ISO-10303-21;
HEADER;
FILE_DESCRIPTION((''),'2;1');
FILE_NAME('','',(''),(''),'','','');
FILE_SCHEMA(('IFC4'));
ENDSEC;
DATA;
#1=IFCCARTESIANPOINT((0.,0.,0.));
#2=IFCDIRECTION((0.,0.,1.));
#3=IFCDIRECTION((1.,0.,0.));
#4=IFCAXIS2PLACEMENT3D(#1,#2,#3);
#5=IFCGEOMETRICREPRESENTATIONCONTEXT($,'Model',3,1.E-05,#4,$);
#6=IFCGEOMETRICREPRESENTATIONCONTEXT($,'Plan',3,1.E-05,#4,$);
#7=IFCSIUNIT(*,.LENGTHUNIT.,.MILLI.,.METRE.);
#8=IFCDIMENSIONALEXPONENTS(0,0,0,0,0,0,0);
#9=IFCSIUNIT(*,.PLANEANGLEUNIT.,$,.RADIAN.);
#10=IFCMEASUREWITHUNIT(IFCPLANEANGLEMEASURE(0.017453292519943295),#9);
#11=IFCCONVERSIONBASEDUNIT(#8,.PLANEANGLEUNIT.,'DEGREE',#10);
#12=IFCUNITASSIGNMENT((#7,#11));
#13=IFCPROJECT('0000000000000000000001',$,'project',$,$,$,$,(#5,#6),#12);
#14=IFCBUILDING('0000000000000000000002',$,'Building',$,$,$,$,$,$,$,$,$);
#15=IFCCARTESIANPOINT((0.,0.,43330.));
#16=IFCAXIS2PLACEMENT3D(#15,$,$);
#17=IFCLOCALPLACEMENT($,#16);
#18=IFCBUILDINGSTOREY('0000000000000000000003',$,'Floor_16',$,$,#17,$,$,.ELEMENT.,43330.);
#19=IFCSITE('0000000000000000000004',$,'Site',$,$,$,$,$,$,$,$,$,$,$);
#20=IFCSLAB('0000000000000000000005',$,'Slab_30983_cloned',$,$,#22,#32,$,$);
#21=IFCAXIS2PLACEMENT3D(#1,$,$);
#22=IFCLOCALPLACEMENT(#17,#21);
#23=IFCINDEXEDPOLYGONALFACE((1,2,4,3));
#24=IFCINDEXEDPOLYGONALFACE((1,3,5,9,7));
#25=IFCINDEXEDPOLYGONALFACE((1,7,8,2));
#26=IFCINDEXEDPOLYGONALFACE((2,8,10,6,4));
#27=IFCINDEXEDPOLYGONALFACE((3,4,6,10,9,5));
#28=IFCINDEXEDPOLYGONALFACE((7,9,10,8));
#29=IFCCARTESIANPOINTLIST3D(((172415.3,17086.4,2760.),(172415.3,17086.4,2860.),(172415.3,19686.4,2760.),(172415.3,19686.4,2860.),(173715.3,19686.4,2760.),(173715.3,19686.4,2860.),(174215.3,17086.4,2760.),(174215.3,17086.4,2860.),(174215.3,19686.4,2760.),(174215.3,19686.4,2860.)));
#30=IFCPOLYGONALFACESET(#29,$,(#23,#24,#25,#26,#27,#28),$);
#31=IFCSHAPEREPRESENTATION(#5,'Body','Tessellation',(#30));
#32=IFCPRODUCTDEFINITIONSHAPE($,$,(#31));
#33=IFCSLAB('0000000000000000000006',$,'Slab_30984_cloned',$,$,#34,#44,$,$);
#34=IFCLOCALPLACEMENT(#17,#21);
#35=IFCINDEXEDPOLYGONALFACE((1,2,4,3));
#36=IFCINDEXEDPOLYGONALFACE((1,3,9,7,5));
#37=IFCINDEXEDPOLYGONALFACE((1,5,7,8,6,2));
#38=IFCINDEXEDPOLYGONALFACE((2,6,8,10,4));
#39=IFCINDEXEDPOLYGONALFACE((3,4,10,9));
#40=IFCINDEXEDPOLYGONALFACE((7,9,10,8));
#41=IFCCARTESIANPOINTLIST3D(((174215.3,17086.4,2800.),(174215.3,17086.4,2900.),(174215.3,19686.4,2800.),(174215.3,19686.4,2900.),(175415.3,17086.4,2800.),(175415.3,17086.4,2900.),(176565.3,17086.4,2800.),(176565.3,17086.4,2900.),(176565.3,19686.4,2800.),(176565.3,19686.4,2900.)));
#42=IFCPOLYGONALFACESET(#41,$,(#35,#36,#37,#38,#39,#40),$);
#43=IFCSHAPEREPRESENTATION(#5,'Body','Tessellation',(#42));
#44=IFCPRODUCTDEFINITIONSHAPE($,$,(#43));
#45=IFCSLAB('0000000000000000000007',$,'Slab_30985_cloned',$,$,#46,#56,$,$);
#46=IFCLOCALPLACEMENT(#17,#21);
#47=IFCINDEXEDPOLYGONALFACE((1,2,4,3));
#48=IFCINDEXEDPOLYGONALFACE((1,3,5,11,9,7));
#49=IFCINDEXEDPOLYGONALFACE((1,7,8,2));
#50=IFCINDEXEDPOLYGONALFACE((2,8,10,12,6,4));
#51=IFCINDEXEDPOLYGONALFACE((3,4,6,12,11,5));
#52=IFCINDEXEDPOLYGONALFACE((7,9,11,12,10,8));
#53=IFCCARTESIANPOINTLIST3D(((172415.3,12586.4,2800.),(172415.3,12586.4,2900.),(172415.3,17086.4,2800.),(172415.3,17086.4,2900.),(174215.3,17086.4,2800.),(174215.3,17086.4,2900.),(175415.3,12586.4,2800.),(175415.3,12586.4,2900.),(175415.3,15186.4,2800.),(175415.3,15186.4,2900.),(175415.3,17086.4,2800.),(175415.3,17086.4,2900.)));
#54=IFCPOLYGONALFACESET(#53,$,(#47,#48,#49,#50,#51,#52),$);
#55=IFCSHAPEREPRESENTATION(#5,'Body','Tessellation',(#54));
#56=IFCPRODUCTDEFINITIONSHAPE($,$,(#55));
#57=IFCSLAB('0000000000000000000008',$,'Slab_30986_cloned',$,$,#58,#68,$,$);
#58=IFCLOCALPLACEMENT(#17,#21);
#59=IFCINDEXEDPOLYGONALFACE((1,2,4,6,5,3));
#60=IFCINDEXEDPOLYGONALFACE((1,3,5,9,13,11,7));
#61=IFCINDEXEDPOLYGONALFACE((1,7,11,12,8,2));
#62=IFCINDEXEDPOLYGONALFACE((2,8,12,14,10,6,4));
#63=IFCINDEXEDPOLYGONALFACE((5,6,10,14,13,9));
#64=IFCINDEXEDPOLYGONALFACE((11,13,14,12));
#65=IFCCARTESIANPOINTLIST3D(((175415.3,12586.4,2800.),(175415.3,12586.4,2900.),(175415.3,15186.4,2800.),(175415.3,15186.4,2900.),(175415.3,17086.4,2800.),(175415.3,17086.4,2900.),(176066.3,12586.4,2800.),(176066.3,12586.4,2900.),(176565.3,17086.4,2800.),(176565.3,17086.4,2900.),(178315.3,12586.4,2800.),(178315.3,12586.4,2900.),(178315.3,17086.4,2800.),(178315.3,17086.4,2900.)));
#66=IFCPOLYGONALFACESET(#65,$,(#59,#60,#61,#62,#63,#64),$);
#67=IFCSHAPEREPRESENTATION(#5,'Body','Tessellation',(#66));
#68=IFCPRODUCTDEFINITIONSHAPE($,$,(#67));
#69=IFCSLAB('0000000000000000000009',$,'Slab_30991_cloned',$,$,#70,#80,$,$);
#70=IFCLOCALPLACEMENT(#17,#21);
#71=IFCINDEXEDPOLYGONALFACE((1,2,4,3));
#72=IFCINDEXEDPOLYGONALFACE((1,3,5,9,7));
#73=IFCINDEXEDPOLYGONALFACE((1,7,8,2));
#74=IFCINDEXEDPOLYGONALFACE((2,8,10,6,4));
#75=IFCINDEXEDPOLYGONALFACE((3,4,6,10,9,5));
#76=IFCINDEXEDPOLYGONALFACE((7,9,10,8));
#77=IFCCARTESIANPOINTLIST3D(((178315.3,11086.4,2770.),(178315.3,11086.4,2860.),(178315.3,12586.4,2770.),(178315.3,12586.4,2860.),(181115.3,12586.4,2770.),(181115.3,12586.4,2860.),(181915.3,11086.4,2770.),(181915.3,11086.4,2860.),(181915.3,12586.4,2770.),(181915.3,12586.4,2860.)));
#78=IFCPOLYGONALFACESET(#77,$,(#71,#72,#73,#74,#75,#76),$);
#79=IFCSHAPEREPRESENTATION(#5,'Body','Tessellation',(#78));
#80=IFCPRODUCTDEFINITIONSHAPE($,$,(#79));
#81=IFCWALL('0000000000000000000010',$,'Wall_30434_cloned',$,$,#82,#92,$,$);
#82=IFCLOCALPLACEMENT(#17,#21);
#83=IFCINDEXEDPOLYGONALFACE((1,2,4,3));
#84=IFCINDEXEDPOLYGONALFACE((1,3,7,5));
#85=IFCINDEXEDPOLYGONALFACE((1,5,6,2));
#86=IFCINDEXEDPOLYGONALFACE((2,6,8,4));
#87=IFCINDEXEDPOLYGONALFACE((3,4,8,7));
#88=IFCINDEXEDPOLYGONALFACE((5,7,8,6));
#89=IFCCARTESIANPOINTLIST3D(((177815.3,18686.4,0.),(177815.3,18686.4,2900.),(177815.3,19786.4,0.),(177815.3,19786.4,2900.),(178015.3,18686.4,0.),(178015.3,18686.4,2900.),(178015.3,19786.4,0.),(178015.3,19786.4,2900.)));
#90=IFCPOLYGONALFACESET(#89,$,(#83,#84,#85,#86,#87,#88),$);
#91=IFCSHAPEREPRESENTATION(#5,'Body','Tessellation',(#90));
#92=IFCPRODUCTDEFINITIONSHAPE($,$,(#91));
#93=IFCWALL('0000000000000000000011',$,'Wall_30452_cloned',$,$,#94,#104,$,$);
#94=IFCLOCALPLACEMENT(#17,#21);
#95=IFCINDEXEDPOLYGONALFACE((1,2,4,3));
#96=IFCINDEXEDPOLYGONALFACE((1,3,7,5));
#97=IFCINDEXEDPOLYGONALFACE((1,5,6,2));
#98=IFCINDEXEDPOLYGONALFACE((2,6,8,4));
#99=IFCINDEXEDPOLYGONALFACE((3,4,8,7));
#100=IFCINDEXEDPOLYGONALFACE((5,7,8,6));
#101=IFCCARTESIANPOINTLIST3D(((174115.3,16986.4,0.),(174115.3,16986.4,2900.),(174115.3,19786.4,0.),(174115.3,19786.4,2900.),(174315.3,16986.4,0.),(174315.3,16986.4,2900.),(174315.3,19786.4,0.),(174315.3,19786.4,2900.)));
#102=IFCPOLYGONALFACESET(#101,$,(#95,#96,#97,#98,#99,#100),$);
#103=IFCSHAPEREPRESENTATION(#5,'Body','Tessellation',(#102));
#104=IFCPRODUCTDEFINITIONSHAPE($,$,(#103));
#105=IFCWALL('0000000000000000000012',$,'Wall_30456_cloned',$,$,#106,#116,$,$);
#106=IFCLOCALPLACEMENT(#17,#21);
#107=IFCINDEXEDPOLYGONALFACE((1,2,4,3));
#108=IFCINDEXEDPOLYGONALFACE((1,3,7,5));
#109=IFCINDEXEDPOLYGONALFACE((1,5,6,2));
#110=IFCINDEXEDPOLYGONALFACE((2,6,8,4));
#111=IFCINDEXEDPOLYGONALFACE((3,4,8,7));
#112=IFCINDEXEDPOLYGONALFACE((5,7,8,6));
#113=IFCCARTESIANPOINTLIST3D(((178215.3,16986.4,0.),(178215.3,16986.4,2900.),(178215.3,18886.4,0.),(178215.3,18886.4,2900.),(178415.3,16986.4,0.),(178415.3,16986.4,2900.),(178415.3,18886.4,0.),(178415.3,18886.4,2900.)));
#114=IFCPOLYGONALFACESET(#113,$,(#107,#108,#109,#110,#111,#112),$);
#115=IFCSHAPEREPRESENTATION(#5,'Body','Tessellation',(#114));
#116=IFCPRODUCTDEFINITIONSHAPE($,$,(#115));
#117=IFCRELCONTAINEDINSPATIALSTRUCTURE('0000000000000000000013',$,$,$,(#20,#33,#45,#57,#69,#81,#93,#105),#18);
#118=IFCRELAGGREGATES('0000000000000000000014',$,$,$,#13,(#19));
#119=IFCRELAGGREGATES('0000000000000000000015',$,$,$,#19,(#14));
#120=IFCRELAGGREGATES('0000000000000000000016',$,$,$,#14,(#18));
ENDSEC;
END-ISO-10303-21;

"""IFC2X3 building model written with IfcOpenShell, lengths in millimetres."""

from ifc_helpers import new_model, entity, si_unit, converted_unit, frame, origin_with_axes, origin_2d, place, context, project, spatial, polyline, rectangle, outline, extrude, source, transform, mapped, element, save


model = new_model("IFC2X3")

# Units and contexts
model_context = context("Model", 3, precision=1e-05, world=origin_with_axes())
plan_context = context("Plan", 3, precision=1e-05, world=origin_with_axes())
ifc_project = project(units=[si_unit("LENGTHUNIT", "METRE", prefix="MILLI"), converted_unit("PLANEANGLEUNIT", "DEGREE", entity("IfcPlaneAngleMeasure", 0.017453292519943295), si_unit("PLANEANGLEUNIT", "RADIAN"), dimensions=[0, 0, 0, 0, 0, 0, 0])], contexts=[model_context, plan_context])

# Site, building, storey
site = spatial("IfcSite", under=ifc_project, Name="Site")
building = spatial("IfcBuilding", under=site, Name="Building")
storey_placement = place(None, frame((0.0, 0.0, 43330.0)))
storey = spatial("IfcBuildingStorey", under=building, at=storey_placement, Name="Floor_16", CompositionType="ELEMENT", Elevation=43330.0)

# Slabs
shared_shape_1 = source(origin_with_axes(), model_context, "Body", "SweptSolid", [
    extrude(outline(polyline([(0.0, 0.0), (2600.0, 0.0), (2600.0, 1800.0), (0.0, 1800.0), (0.0, 1300.0)])), origin_with_axes(), (0.0, 0.0, 1.0), 100.0),
])
slab_1_placement = place(storey_placement, frame((172415.3, 19686.4, 2760.0), z_axis=(0.0, 0.0, 1.0), x_axis=(0.0, -2599.99, 0.0)))
element("IfcSlab", 1, at=slab_1_placement, inside=storey, Name="Slab_30983_cloned", context=model_context, shape_type="MappedRepresentation", body=[
    mapped(shared_shape_1, transform((0.0, 0.0, 0.0), x_axis=(1.0, 0.0, 0.0), y_axis=(0.0, 1.0, 0.0), z_axis=(0.0, 0.0, 1.0), scale=1.0)),
])
shared_shape_2 = source(origin_with_axes(), model_context, "Body", "SweptSolid", [
    extrude(outline(polyline([(0.0, 0.0), (2600.0, 0.0), (2600.0, 1200.0), (2600.0, 2350.0), (0.0, 2350.0)])), origin_with_axes(), (0.0, 0.0, 1.0), 100.0),
])
slab_2_placement = place(storey_placement, frame((174215.3, 19686.4, 2800.0), z_axis=(0.0, 0.0, 1.0), x_axis=(0.0, -2599.99, 0.0)))
element("IfcSlab", 2, at=slab_2_placement, inside=storey, Name="Slab_30984_cloned", context=model_context, shape_type="MappedRepresentation", body=[
    mapped(shared_shape_2, transform((0.0, 0.0, 0.0), x_axis=(1.0, 0.0, 0.0), y_axis=(0.0, 1.0, 0.0), z_axis=(0.0, 0.0, 1.0), scale=1.0)),
])
shared_shape_3 = source(origin_with_axes(), model_context, "Body", "SweptSolid", [
    extrude(outline(polyline([(0.0, 0.0), (4500.0, 0.0), (4500.0, 3000.0), (1900.0, 3000.0), (0.0, 3000.0), (0.0, 1800.0)])), origin_with_axes(), (0.0, 0.0, 1.0), 100.0),
])
slab_3_placement = place(storey_placement, frame((172415.3, 17086.4, 2800.0), z_axis=(0.0, 0.0, 1.0), x_axis=(0.0, -4500.031, 0.0)))
element("IfcSlab", 3, at=slab_3_placement, inside=storey, Name="Slab_30985_cloned", context=model_context, shape_type="MappedRepresentation", body=[
    mapped(shared_shape_3, transform((0.0, 0.0, 0.0), x_axis=(1.0, 0.0, 0.0), y_axis=(0.0, 1.0, 0.0), z_axis=(0.0, 0.0, 1.0), scale=1.0)),
])
shared_shape_4 = source(origin_with_axes(), model_context, "Body", "SweptSolid", [
    extrude(outline(polyline([(0.0, 0.0), (1900.0, 0.0), (4500.0, 0.0), (4500.0, 651.0), (4500.0, 2900.0), (0.0, 2900.0), (0.0, 1150.0)])), origin_with_axes(), (0.0, 0.0, 1.0), 100.0),
])
slab_4_placement = place(storey_placement, frame((175415.3, 17086.4, 2800.0), z_axis=(0.0, 0.0, 1.0), x_axis=(-0.006, -1900.025, 0.0)))
element("IfcSlab", 4, at=slab_4_placement, inside=storey, Name="Slab_30986_cloned", context=model_context, shape_type="MappedRepresentation", body=[
    mapped(shared_shape_4, transform((0.0, 0.0, 0.0), x_axis=(1.0, 0.0, 0.0), y_axis=(0.0, 1.0, 0.0), z_axis=(0.0, 0.0, 1.0), scale=1.0)),
])
shared_shape_5 = source(origin_with_axes(), model_context, "Body", "SweptSolid", [
    extrude(outline(polyline([(0.0, 0.0), (1500.0, 0.0), (1500.0, 3600.0), (0.0, 3600.0), (0.0, 2800.0)])), origin_with_axes(), (0.0, 0.0, 1.0), 90.0),
])
slab_5_placement = place(storey_placement, frame((178315.3, 12586.4, 2770.0), z_axis=(0.0, 0.0, 1.0), x_axis=(0.0, -1500.0, 0.0)))
element("IfcSlab", 5, at=slab_5_placement, inside=storey, Name="Slab_30991_cloned", context=model_context, shape_type="MappedRepresentation", body=[
    mapped(shared_shape_5, transform((0.0, 0.0, 0.0), x_axis=(1.0, 0.0, 0.0), y_axis=(0.0, 1.0, 0.0), z_axis=(0.0, 0.0, 1.0), scale=1.0)),
])

# Walls
shared_shape_6 = source(origin_with_axes(), model_context, "Body", "SweptSolid", [
    extrude(rectangle(XDim=1100.0, YDim=200.0, at=origin_2d()), origin_with_axes(), (0.0, 0.0, 1.0), 2900.0),
])
wall_1_placement = place(storey_placement, frame((177915.3, 19236.4, 0.0), z_axis=(0.0, 0.0, 1.0), x_axis=(0.000094, 1099.995689, 0.0)))
element("IfcWall", 6, at=wall_1_placement, inside=storey, Name="Wall_30434_cloned", context=model_context, shape_type="MappedRepresentation", body=[
    mapped(shared_shape_6, transform((0.0, 0.0, 0.0), x_axis=(1.0, 0.0, 0.0), y_axis=(0.0, 1.0, 0.0), z_axis=(0.0, 0.0, 1.0), scale=1.0)),
])
shared_shape_7 = source(origin_with_axes(), model_context, "Body", "SweptSolid", [
    extrude(rectangle(XDim=2800.0, YDim=200.0, at=origin_2d()), origin_with_axes(), (0.0, 0.0, 1.0), 2900.0),
])
wall_2_placement = place(storey_placement, frame((174215.3, 18386.4, 0.0), z_axis=(0.0, 0.0, 1.0), x_axis=(0.0, 2799.990212, 0.0)))
element("IfcWall", 7, at=wall_2_placement, inside=storey, Name="Wall_30452_cloned", context=model_context, shape_type="MappedRepresentation", body=[
    mapped(shared_shape_7, transform((0.0, 0.0, 0.0), x_axis=(1.0, 0.0, 0.0), y_axis=(0.0, 1.0, 0.0), z_axis=(0.0, 0.0, 1.0), scale=1.0)),
])
shared_shape_8 = source(origin_with_axes(), model_context, "Body", "SweptSolid", [
    extrude(rectangle(XDim=1900.0, YDim=200.0, at=origin_2d()), origin_with_axes(), (0.0, 0.0, 1.0), 2900.0),
])
wall_3_placement = place(storey_placement, frame((178315.3, 17936.4, 0.0), z_axis=(0.0, 0.0, 1.0), x_axis=(0.000403, 1899.988898, 0.0)))
element("IfcWall", 8, at=wall_3_placement, inside=storey, Name="Wall_30456_cloned", context=model_context, shape_type="MappedRepresentation", body=[
    mapped(shared_shape_8, transform((0.0, 0.0, 0.0), x_axis=(1.0, 0.0, 0.0), y_axis=(0.0, 1.0, 0.0), z_axis=(0.0, 0.0, 1.0), scale=1.0)),
])

save(model, "model.ifc")
